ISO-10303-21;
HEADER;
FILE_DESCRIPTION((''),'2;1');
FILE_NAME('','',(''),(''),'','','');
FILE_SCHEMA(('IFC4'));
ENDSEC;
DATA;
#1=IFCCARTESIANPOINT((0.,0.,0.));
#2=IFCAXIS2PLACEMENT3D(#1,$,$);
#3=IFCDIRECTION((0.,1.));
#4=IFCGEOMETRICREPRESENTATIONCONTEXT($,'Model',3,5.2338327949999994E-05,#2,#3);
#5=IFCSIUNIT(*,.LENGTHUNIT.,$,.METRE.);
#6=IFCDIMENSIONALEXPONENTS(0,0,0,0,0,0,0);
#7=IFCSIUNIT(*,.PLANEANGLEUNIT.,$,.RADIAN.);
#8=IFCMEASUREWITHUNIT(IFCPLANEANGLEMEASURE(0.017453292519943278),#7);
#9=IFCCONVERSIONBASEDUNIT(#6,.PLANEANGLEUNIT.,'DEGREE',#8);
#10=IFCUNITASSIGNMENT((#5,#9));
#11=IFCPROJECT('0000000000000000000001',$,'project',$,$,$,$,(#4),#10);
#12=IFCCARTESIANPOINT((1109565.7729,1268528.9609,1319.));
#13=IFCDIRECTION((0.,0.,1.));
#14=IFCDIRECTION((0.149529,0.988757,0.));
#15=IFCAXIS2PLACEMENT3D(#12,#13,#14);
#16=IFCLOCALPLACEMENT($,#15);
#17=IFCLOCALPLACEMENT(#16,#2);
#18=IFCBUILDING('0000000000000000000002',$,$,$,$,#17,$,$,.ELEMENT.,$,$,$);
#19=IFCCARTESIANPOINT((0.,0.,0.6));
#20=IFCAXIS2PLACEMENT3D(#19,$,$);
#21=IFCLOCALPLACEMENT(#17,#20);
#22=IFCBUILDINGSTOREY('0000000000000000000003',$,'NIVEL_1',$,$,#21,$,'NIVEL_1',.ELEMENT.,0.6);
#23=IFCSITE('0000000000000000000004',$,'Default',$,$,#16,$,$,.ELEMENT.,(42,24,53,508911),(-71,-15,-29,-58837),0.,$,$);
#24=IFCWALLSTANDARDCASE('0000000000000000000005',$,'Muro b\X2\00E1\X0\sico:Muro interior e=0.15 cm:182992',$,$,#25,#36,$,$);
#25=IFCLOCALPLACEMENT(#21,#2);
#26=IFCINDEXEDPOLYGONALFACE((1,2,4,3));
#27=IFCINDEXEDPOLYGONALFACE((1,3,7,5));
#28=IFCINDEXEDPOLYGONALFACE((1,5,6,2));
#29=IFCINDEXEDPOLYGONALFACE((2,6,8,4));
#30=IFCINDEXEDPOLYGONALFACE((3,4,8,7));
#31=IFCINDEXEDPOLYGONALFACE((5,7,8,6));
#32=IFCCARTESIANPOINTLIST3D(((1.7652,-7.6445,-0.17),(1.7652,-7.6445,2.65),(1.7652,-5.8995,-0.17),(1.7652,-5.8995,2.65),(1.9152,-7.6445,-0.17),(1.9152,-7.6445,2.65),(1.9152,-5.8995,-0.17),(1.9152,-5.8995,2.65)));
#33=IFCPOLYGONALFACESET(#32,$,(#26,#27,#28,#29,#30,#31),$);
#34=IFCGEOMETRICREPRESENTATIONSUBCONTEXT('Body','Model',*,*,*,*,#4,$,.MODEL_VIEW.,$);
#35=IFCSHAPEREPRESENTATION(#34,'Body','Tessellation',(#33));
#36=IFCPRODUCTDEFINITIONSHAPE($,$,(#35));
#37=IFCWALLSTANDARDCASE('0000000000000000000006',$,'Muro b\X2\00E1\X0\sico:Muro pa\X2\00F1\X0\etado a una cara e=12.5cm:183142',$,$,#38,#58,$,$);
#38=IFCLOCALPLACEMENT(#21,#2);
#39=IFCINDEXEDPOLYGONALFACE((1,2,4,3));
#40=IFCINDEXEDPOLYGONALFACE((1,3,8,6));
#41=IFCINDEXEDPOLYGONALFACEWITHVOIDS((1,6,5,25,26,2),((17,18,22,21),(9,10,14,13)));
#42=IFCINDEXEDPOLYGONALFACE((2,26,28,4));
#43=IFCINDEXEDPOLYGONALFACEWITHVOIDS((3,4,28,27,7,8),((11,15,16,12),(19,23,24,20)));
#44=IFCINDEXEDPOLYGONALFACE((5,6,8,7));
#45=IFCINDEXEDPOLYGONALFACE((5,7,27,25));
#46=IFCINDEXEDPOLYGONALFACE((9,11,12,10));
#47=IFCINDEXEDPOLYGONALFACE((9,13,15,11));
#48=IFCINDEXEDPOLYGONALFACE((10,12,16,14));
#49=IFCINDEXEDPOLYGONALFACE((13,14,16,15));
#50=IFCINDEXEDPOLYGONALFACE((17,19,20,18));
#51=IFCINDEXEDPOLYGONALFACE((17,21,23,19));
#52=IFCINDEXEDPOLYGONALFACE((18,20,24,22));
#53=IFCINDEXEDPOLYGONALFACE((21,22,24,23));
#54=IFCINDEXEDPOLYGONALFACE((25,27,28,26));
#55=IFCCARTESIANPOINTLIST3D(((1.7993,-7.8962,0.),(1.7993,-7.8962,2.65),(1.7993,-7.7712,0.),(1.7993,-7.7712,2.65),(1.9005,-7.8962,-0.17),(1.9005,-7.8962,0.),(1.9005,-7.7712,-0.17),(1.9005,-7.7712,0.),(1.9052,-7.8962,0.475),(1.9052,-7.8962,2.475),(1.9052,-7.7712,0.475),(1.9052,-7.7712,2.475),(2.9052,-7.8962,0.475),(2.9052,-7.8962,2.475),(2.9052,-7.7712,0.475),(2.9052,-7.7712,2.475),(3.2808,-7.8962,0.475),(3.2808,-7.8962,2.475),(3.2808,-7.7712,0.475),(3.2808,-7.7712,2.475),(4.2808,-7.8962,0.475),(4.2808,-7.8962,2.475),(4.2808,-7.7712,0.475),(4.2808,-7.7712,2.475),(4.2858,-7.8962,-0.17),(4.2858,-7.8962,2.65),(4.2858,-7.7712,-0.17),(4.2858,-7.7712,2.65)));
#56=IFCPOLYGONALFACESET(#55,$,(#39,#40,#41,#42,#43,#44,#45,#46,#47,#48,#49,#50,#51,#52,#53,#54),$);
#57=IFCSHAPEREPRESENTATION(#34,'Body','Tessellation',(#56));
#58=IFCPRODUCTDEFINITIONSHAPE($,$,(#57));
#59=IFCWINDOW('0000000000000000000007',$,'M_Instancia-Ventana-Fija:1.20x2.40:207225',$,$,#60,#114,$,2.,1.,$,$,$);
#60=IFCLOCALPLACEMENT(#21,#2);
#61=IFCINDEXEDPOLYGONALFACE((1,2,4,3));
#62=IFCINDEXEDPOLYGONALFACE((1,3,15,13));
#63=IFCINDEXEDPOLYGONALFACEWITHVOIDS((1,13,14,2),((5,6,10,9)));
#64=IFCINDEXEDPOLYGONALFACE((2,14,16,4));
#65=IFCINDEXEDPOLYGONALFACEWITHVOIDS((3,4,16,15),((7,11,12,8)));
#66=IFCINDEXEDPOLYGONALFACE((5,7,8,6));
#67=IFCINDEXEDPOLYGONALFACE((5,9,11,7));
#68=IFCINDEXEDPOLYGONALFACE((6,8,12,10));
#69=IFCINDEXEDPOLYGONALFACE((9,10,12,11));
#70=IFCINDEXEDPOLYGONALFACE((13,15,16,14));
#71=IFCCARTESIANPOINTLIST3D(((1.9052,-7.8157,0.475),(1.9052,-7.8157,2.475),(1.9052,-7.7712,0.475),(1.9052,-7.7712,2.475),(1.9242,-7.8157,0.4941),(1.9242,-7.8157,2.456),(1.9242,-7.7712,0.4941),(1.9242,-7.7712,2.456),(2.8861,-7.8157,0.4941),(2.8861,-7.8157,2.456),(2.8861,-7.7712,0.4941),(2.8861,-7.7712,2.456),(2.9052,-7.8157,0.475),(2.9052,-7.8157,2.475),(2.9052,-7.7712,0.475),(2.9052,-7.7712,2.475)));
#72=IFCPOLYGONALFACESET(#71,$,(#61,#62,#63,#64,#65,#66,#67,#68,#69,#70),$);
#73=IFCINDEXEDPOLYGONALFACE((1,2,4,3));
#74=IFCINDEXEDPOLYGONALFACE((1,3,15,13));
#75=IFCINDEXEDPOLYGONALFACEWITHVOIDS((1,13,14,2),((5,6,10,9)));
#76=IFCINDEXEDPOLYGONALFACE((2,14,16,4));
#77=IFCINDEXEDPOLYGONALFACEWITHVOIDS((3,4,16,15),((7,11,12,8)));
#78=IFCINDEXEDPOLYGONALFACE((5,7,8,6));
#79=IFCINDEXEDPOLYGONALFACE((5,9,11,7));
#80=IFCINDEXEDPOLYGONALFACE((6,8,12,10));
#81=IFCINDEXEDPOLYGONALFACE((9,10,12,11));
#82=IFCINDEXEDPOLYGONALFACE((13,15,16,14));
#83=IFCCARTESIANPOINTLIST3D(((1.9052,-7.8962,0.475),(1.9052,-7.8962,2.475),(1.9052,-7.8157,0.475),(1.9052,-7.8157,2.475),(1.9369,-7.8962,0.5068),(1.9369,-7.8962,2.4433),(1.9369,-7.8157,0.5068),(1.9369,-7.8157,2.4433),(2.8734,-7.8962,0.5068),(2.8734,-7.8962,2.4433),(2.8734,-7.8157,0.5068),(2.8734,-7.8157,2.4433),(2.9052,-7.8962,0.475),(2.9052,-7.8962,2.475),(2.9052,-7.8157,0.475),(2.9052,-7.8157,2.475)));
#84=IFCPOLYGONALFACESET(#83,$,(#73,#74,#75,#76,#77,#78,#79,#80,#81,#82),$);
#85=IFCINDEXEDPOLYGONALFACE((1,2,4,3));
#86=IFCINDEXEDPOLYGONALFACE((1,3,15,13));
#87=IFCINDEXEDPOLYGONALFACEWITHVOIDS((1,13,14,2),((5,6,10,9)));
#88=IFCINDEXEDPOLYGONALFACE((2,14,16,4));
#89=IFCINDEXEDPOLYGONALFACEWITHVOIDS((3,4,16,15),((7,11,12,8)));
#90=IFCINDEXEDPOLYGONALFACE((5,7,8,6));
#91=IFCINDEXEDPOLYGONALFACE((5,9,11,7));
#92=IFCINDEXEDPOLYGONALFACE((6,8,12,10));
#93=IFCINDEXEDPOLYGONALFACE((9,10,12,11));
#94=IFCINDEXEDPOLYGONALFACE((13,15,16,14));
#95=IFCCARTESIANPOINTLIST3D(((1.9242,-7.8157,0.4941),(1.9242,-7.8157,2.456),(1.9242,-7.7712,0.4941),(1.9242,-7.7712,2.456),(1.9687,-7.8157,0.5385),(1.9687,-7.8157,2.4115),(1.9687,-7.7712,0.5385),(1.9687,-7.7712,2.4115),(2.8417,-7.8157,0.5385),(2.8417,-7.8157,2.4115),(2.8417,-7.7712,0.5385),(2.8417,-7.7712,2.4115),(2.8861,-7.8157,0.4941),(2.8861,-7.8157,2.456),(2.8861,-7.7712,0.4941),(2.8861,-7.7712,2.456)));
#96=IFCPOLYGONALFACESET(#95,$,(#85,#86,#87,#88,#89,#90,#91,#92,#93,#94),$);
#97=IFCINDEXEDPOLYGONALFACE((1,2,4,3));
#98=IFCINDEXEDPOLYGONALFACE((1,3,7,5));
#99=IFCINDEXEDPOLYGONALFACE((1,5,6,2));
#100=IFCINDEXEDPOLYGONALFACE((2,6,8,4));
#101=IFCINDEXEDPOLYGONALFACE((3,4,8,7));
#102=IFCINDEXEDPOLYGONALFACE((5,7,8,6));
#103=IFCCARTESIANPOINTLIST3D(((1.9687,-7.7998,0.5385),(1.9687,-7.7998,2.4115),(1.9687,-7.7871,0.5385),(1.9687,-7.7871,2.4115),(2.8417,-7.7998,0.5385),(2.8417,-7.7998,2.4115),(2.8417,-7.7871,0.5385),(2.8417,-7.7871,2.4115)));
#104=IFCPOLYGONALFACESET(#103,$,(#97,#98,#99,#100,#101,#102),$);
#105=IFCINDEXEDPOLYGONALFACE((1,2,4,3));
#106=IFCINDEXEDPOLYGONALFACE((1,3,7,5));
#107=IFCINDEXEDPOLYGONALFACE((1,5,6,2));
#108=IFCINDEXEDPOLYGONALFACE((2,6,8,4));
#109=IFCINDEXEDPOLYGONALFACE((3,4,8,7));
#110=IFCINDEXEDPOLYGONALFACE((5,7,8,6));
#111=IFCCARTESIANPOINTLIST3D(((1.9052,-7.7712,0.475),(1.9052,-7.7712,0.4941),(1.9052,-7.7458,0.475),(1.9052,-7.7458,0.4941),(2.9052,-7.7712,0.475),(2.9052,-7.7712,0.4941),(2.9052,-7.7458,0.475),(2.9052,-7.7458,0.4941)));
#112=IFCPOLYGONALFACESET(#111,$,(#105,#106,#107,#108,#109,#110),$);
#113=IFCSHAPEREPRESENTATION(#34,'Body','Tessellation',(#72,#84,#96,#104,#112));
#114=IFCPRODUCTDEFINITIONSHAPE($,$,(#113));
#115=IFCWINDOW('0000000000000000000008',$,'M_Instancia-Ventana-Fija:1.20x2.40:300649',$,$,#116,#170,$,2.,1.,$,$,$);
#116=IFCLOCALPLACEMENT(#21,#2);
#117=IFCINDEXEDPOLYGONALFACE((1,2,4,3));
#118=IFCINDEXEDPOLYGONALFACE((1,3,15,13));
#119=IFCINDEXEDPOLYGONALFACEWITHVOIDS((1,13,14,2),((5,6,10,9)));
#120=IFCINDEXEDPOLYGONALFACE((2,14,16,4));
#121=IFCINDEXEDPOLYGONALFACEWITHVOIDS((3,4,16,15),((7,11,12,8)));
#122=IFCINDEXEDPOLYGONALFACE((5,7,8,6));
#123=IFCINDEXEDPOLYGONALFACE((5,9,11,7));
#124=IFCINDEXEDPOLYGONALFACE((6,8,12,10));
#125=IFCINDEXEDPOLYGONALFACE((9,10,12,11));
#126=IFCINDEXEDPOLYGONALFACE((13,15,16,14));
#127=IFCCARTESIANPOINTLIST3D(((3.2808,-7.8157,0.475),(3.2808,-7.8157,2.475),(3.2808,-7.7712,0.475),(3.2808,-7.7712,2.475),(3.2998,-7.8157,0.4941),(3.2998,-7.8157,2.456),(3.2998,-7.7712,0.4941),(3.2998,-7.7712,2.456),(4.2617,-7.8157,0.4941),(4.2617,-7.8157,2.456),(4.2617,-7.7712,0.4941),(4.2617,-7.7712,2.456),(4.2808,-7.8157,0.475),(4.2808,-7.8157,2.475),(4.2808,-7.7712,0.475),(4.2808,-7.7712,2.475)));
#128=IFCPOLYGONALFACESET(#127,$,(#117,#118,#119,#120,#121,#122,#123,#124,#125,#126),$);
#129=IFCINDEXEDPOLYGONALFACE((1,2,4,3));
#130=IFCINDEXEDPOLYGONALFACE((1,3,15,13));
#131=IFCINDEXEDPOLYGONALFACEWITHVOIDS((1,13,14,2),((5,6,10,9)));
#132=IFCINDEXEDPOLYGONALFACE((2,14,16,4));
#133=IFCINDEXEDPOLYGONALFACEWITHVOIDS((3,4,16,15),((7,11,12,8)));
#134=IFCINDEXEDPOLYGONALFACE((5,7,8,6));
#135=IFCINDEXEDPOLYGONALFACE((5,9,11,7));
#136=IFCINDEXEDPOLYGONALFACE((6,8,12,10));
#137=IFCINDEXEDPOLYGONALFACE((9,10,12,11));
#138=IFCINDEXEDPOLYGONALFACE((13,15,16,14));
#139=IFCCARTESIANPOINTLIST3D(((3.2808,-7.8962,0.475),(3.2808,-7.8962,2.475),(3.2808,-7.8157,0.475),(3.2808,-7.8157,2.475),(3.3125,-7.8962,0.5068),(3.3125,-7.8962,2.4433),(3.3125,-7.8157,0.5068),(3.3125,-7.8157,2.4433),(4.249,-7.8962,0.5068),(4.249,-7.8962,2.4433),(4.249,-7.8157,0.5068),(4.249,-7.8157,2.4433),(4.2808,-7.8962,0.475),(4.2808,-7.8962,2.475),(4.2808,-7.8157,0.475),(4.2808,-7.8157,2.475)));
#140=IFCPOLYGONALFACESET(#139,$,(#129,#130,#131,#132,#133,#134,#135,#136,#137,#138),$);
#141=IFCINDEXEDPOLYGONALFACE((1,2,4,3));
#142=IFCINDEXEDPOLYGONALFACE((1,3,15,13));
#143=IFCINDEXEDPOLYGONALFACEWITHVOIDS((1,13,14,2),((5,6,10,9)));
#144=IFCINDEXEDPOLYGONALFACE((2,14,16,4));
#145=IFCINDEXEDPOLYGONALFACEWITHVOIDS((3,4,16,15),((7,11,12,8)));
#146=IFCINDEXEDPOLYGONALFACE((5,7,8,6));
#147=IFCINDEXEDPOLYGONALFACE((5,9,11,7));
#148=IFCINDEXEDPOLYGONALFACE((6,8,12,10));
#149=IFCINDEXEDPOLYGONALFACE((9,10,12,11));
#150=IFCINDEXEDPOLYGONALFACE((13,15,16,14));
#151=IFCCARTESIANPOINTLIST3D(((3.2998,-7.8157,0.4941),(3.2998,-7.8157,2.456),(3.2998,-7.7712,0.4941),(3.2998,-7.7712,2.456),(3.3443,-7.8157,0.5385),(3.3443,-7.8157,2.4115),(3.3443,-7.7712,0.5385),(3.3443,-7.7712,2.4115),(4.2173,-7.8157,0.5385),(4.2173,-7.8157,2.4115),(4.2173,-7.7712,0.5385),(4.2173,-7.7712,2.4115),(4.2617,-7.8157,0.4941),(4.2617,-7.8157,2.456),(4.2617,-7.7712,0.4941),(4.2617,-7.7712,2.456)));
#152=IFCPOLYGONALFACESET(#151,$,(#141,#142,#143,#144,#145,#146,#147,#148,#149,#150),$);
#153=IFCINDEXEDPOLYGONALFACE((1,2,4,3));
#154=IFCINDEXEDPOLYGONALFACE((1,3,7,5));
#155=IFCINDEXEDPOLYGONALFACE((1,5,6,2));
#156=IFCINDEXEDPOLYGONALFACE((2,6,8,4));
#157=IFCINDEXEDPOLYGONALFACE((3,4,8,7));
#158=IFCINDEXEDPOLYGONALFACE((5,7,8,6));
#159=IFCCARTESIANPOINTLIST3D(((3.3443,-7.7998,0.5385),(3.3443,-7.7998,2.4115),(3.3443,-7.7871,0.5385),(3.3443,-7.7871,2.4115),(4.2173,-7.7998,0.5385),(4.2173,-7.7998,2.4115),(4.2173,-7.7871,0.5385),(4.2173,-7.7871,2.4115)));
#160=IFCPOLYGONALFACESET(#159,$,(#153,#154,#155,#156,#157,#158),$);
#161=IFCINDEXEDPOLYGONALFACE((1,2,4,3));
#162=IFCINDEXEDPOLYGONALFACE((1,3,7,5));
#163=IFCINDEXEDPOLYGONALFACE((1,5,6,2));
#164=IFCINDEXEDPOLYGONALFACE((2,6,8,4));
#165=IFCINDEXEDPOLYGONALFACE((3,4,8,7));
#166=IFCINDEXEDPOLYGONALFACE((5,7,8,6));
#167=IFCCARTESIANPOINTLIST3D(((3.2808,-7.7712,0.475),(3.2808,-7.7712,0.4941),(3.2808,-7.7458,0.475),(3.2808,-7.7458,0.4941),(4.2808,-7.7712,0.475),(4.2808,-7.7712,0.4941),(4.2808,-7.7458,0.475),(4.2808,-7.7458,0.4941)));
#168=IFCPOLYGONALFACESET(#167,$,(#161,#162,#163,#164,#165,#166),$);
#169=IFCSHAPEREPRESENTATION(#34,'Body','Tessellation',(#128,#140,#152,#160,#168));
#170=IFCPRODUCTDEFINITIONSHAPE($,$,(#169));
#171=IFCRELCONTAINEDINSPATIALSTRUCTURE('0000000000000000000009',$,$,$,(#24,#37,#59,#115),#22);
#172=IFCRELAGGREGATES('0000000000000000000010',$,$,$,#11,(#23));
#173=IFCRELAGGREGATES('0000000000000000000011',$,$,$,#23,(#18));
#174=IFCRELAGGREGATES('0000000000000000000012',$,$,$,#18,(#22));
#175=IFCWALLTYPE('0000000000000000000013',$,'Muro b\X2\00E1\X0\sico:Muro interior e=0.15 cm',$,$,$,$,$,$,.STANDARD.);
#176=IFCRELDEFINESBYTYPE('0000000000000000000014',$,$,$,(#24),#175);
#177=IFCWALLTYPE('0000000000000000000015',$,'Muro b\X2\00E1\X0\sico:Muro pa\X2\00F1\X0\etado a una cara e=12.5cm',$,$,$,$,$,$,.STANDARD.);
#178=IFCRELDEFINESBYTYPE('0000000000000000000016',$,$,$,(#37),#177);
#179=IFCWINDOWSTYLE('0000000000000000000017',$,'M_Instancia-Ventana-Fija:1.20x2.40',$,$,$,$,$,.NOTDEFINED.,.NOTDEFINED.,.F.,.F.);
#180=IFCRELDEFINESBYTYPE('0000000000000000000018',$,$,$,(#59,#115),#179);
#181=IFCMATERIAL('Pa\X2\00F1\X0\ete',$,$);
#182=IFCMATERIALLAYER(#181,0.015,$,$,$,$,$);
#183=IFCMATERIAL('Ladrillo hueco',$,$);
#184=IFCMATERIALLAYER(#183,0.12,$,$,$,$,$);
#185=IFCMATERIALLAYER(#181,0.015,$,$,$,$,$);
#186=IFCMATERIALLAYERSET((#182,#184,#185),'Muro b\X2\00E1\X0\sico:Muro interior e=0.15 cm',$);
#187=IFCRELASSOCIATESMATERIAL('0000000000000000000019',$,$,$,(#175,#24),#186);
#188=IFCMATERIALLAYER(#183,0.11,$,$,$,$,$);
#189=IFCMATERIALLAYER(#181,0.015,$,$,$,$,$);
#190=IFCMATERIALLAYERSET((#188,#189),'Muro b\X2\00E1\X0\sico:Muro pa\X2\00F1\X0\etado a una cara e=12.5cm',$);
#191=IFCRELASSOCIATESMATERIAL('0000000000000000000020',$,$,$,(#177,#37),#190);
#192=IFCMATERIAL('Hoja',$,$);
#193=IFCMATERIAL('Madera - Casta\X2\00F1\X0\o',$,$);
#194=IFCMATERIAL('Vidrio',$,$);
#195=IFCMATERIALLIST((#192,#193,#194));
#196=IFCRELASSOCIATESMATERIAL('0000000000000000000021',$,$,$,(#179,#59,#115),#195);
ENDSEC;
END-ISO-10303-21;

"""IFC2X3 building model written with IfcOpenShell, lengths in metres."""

from ifc_helpers import new_model, entity, si_unit, converted_unit, direction, frame, frame_2d, origin, origin_2d_with_axis, place, context, subcontext, project, spatial, polyline, rectangle, outline, extrude, source, transform, mapped, material, material_list, layer, layer_set, layer_usage, type_object, type_shapes, element, fill, save


model = new_model("IFC2X3")

# Units and contexts
model_context = context("Model", 3, precision=5.2338327949999994e-05, world=origin(), true_north=direction((0.0, 1.0)))
body_context = subcontext(model_context, "Body", "Model", "MODEL_VIEW")
ifc_project = project(units=[si_unit("LENGTHUNIT", "METRE"), converted_unit("PLANEANGLEUNIT", "DEGREE", entity("IfcPlaneAngleMeasure", 0.017453292519943278), si_unit("PLANEANGLEUNIT", "RADIAN"), dimensions=[0, 0, 0, 0, 0, 0, 0])], contexts=[model_context])

# Site, building, storey
site_placement = place(None, frame((1109565.7729, 1268528.9609, 1319.0), z_axis=(0.0, 0.0, 1.0), x_axis=(0.149529, 0.988757, 0.0)))
site = spatial("IfcSite", under=ifc_project, at=site_placement, Name="Default", CompositionType="ELEMENT", RefLatitude=(42, 24, 53, 508911), RefLongitude=(-71, -15, -29, -58837), RefElevation=0.0)
building_placement = place(site_placement, origin())
building = spatial("IfcBuilding", under=site, at=building_placement, CompositionType="ELEMENT")
storey_placement = place(building_placement, frame((0.0, 0.0, 0.6)))
storey = spatial("IfcBuildingStorey", under=building, at=storey_placement, Name="NIVEL_1", LongName="NIVEL_1", CompositionType="ELEMENT", Elevation=0.6)

# Wall
ifc_material_1 = material(Name="Pañete")
ifc_layer_1 = layer(ifc_material_1, 0.015)
ifc_material_2 = material(Name="Ladrillo hueco")
ifc_layer_2 = layer(ifc_material_2, 0.12)
ifc_layer_3 = layer(ifc_material_1, 0.015)
ifc_layer_set_1 = layer_set([ifc_layer_1, ifc_layer_2, ifc_layer_3], Name="Muro básico:Muro interior e=0.15 cm")
wall_type_1 = type_object("IfcWallType", Name="Muro básico:Muro interior e=0.15 cm", PredefinedType="STANDARD", material=ifc_layer_set_1)
ifc_layer_usage_1 = layer_usage(ifc_layer_set_1, "AXIS2", "POSITIVE", -0.075)
wall_1_placement = place(storey_placement, frame((1.8402, -7.6445, -0.17), z_axis=(0.0, 0.0, 1.0), x_axis=(0.0, 1.0, 0.0)))
element("IfcWallStandardCase", 1, at=wall_1_placement, inside=storey, type_object=wall_type_1, material=ifc_layer_usage_1, Name="Muro básico:Muro interior e=0.15 cm:182992", context=body_context, shape_type="SweptSolid", body=[
    extrude(rectangle(XDim=1.745, YDim=0.15, at=frame_2d((0.8725, 0.0), x_axis=(-1.0, 0.0))), origin(), (0.0, 0.0, 1.0), 2.82),
])

# Wall, openings, windows
ifc_layer_4 = layer(ifc_material_2, 0.11)
ifc_layer_5 = layer(ifc_material_1, 0.015)
ifc_layer_set_2 = layer_set([ifc_layer_4, ifc_layer_5], Name="Muro básico:Muro pañetado a una cara e=12.5cm")
ifc_layer_usage_2 = layer_usage(ifc_layer_set_2, "AXIS2", "POSITIVE", -0.0625)
wall_type_2 = type_object("IfcWallType", Name="Muro básico:Muro pañetado a una cara e=12.5cm", PredefinedType="STANDARD", material=ifc_layer_set_2)
wall_2_placement = place(storey_placement, frame((1.7993, -7.8337, -0.17)))
wall_2 = element("IfcWallStandardCase", 2, at=wall_2_placement, inside=storey, type_object=wall_type_2, material=ifc_layer_usage_2, Name="Muro básico:Muro pañetado a una cara e=12.5cm:183142", context=body_context, shape_type="SweptSolid", body=[
    extrude(rectangle(XDim=2.4864, YDim=0.125, at=frame_2d((1.2432, 0.0), x_axis=(-1.0, 0.0))), origin(), (0.0, 0.0, 1.0), 2.82),
])
opening_1_placement = place(wall_2_placement, origin())
element("IfcOpeningElement", 3, at=opening_1_placement, cuts=wall_2, ObjectType="Opening", context=body_context, shape_type="SweptSolid", body=[
    extrude(rectangle(XDim=0.17, YDim=0.1011, at=frame_2d((0.0, 0.0), x_axis=(1.0, 0.0))), frame((0.0506, 0.0625, 0.085), z_axis=(0.0, -1.0, 0.0), x_axis=(0.0, 0.0, 1.0)), (0.0, 0.0, 1.0), 0.125),
])
opening_2_placement = place(wall_2_placement, frame((0.1058, -0.0625, 0.645)))
opening_2 = element("IfcOpeningElement", 4, at=opening_2_placement, cuts=wall_2, ObjectType="Opening", context=body_context, shape_type="SweptSolid", body=[
    extrude(rectangle(XDim=2.0, YDim=1.0, at=frame_2d((1.0, 0.5), x_axis=(-1.0, 0.0))), frame((0.0, 0.0, 0.0), z_axis=(0.0, 1.0, 0.0), x_axis=(0.0, 0.0, 1.0)), (0.0, 0.0, 1.0), 0.125),
])
opening_3_placement = place(wall_2_placement, frame((1.4814, -0.0625, 0.645)))
opening_3 = element("IfcOpeningElement", 5, at=opening_3_placement, cuts=wall_2, ObjectType="Opening", context=body_context, shape_type="SweptSolid", body=[
    extrude(rectangle(XDim=2.0, YDim=1.0, at=frame_2d((1.0, 0.5), x_axis=(-1.0, 0.0))), frame((0.0, 0.0, 0.0), z_axis=(0.0, 1.0, 0.0), x_axis=(0.0, 0.0, 1.0)), (0.0, 0.0, 1.0), 0.125),
])
ifc_material_3 = material(Name="Hoja")
ifc_material_4 = material(Name="Madera - Castaño")
ifc_material_5 = material(Name="Vidrio")
ifc_material_list = material_list([ifc_material_3, ifc_material_4, ifc_material_5])
window_style = type_object("IfcWindowStyle", Name="M_Instancia-Ventana-Fija:1.20x2.40", ConstructionType="NOTDEFINED", OperationType="NOTDEFINED", ParameterTakesPrecedence=False, Sizeable=False, material=ifc_material_list)
shared_shape_1 = source(origin(), body_context, "Body", "SweptSolid", [
    extrude(outline(polyline([(-1.0, -0.5), (1.0, -0.5), (1.0, 0.5), (-1.0, 0.5), (-1.0, -0.5)]), holes=[polyline([(-0.9809, -0.4809), (-0.9809, 0.481), (0.981, 0.481), (0.981, -0.4809), (-0.9809, -0.4809)])]), frame((0.5, 0.0806, 1.0), z_axis=(0.0, 1.0, 0.0), x_axis=(0.0, 0.0, -1.0)), (0.0, 0.0, 1.0), 0.0444),
    extrude(outline(polyline([(-0.5, -1.0), (0.5, -1.0), (0.5, 1.0), (-0.5, 1.0), (-0.5, -1.0)]), holes=[polyline([(-0.4683, -0.9682), (-0.4683, 0.9683), (0.4682, 0.9683), (0.4682, -0.9682), (-0.4683, -0.9682)])]), frame((0.5, 0.0, 1.0), z_axis=(0.0, 1.0, 0.0), x_axis=(1.0, 0.0, 0.0)), (0.0, 0.0, 1.0), 0.0806),
    extrude(outline(polyline([(-0.4809, -0.981), (0.4809, -0.981), (0.4809, 0.981), (-0.4809, 0.981), (-0.4809, -0.981)]), holes=[polyline([(-0.4365, -0.9365), (-0.4365, 0.9365), (0.4365, 0.9365), (0.4365, -0.9365), (-0.4365, -0.9365)])]), frame((0.5, 0.0806, 1.0), z_axis=(0.0, 1.0, 0.0), x_axis=(1.0, 0.0, 0.0)), (0.0, 0.0, 1.0), 0.0444),
    extrude(rectangle(XDim=0.0127, YDim=0.873, at=frame_2d((0.0, 0.0), x_axis=(1.0, 0.0))), frame((0.5, 0.1028, 0.0635), z_axis=(0.0, 0.0, 1.0), x_axis=(0.0, 1.0, 0.0)), (0.0, 0.0, 1.0), 1.873),
    extrude(rectangle(XDim=0.0254, YDim=1.0, at=origin_2d_with_axis()), frame((0.5, 0.1377, 0.0), z_axis=(0.0, 0.0, 1.0), x_axis=(0.0, -1.0, 0.0)), (0.0, 0.0, 1.0), 0.019),
])
type_shapes(window_style, [shared_shape_1])
window_1_placement = place(opening_2_placement, origin())
window_1 = element("IfcWindow", 6, at=window_1_placement, inside=storey, type_object=window_style, material=ifc_material_list, Name="M_Instancia-Ventana-Fija:1.20x2.40:207225", OverallHeight=2.0, OverallWidth=1.0, context=body_context, shape_type="MappedRepresentation", body=[
    mapped(shared_shape_1, transform((0.0, 0.0, 0.0), scale=1.0)),
])
fill(opening_2, window_1)
window_2_placement = place(opening_3_placement, origin())
window_2 = element("IfcWindow", 7, at=window_2_placement, inside=storey, type_object=window_style, material=ifc_material_list, Name="M_Instancia-Ventana-Fija:1.20x2.40:300649", OverallHeight=2.0, OverallWidth=1.0, context=body_context, shape_type="MappedRepresentation", body=[
    mapped(shared_shape_1, transform((0.0, 0.0, 0.0), scale=1.0)),
])
fill(opening_3, window_2)

save(model, "model.ifc")
